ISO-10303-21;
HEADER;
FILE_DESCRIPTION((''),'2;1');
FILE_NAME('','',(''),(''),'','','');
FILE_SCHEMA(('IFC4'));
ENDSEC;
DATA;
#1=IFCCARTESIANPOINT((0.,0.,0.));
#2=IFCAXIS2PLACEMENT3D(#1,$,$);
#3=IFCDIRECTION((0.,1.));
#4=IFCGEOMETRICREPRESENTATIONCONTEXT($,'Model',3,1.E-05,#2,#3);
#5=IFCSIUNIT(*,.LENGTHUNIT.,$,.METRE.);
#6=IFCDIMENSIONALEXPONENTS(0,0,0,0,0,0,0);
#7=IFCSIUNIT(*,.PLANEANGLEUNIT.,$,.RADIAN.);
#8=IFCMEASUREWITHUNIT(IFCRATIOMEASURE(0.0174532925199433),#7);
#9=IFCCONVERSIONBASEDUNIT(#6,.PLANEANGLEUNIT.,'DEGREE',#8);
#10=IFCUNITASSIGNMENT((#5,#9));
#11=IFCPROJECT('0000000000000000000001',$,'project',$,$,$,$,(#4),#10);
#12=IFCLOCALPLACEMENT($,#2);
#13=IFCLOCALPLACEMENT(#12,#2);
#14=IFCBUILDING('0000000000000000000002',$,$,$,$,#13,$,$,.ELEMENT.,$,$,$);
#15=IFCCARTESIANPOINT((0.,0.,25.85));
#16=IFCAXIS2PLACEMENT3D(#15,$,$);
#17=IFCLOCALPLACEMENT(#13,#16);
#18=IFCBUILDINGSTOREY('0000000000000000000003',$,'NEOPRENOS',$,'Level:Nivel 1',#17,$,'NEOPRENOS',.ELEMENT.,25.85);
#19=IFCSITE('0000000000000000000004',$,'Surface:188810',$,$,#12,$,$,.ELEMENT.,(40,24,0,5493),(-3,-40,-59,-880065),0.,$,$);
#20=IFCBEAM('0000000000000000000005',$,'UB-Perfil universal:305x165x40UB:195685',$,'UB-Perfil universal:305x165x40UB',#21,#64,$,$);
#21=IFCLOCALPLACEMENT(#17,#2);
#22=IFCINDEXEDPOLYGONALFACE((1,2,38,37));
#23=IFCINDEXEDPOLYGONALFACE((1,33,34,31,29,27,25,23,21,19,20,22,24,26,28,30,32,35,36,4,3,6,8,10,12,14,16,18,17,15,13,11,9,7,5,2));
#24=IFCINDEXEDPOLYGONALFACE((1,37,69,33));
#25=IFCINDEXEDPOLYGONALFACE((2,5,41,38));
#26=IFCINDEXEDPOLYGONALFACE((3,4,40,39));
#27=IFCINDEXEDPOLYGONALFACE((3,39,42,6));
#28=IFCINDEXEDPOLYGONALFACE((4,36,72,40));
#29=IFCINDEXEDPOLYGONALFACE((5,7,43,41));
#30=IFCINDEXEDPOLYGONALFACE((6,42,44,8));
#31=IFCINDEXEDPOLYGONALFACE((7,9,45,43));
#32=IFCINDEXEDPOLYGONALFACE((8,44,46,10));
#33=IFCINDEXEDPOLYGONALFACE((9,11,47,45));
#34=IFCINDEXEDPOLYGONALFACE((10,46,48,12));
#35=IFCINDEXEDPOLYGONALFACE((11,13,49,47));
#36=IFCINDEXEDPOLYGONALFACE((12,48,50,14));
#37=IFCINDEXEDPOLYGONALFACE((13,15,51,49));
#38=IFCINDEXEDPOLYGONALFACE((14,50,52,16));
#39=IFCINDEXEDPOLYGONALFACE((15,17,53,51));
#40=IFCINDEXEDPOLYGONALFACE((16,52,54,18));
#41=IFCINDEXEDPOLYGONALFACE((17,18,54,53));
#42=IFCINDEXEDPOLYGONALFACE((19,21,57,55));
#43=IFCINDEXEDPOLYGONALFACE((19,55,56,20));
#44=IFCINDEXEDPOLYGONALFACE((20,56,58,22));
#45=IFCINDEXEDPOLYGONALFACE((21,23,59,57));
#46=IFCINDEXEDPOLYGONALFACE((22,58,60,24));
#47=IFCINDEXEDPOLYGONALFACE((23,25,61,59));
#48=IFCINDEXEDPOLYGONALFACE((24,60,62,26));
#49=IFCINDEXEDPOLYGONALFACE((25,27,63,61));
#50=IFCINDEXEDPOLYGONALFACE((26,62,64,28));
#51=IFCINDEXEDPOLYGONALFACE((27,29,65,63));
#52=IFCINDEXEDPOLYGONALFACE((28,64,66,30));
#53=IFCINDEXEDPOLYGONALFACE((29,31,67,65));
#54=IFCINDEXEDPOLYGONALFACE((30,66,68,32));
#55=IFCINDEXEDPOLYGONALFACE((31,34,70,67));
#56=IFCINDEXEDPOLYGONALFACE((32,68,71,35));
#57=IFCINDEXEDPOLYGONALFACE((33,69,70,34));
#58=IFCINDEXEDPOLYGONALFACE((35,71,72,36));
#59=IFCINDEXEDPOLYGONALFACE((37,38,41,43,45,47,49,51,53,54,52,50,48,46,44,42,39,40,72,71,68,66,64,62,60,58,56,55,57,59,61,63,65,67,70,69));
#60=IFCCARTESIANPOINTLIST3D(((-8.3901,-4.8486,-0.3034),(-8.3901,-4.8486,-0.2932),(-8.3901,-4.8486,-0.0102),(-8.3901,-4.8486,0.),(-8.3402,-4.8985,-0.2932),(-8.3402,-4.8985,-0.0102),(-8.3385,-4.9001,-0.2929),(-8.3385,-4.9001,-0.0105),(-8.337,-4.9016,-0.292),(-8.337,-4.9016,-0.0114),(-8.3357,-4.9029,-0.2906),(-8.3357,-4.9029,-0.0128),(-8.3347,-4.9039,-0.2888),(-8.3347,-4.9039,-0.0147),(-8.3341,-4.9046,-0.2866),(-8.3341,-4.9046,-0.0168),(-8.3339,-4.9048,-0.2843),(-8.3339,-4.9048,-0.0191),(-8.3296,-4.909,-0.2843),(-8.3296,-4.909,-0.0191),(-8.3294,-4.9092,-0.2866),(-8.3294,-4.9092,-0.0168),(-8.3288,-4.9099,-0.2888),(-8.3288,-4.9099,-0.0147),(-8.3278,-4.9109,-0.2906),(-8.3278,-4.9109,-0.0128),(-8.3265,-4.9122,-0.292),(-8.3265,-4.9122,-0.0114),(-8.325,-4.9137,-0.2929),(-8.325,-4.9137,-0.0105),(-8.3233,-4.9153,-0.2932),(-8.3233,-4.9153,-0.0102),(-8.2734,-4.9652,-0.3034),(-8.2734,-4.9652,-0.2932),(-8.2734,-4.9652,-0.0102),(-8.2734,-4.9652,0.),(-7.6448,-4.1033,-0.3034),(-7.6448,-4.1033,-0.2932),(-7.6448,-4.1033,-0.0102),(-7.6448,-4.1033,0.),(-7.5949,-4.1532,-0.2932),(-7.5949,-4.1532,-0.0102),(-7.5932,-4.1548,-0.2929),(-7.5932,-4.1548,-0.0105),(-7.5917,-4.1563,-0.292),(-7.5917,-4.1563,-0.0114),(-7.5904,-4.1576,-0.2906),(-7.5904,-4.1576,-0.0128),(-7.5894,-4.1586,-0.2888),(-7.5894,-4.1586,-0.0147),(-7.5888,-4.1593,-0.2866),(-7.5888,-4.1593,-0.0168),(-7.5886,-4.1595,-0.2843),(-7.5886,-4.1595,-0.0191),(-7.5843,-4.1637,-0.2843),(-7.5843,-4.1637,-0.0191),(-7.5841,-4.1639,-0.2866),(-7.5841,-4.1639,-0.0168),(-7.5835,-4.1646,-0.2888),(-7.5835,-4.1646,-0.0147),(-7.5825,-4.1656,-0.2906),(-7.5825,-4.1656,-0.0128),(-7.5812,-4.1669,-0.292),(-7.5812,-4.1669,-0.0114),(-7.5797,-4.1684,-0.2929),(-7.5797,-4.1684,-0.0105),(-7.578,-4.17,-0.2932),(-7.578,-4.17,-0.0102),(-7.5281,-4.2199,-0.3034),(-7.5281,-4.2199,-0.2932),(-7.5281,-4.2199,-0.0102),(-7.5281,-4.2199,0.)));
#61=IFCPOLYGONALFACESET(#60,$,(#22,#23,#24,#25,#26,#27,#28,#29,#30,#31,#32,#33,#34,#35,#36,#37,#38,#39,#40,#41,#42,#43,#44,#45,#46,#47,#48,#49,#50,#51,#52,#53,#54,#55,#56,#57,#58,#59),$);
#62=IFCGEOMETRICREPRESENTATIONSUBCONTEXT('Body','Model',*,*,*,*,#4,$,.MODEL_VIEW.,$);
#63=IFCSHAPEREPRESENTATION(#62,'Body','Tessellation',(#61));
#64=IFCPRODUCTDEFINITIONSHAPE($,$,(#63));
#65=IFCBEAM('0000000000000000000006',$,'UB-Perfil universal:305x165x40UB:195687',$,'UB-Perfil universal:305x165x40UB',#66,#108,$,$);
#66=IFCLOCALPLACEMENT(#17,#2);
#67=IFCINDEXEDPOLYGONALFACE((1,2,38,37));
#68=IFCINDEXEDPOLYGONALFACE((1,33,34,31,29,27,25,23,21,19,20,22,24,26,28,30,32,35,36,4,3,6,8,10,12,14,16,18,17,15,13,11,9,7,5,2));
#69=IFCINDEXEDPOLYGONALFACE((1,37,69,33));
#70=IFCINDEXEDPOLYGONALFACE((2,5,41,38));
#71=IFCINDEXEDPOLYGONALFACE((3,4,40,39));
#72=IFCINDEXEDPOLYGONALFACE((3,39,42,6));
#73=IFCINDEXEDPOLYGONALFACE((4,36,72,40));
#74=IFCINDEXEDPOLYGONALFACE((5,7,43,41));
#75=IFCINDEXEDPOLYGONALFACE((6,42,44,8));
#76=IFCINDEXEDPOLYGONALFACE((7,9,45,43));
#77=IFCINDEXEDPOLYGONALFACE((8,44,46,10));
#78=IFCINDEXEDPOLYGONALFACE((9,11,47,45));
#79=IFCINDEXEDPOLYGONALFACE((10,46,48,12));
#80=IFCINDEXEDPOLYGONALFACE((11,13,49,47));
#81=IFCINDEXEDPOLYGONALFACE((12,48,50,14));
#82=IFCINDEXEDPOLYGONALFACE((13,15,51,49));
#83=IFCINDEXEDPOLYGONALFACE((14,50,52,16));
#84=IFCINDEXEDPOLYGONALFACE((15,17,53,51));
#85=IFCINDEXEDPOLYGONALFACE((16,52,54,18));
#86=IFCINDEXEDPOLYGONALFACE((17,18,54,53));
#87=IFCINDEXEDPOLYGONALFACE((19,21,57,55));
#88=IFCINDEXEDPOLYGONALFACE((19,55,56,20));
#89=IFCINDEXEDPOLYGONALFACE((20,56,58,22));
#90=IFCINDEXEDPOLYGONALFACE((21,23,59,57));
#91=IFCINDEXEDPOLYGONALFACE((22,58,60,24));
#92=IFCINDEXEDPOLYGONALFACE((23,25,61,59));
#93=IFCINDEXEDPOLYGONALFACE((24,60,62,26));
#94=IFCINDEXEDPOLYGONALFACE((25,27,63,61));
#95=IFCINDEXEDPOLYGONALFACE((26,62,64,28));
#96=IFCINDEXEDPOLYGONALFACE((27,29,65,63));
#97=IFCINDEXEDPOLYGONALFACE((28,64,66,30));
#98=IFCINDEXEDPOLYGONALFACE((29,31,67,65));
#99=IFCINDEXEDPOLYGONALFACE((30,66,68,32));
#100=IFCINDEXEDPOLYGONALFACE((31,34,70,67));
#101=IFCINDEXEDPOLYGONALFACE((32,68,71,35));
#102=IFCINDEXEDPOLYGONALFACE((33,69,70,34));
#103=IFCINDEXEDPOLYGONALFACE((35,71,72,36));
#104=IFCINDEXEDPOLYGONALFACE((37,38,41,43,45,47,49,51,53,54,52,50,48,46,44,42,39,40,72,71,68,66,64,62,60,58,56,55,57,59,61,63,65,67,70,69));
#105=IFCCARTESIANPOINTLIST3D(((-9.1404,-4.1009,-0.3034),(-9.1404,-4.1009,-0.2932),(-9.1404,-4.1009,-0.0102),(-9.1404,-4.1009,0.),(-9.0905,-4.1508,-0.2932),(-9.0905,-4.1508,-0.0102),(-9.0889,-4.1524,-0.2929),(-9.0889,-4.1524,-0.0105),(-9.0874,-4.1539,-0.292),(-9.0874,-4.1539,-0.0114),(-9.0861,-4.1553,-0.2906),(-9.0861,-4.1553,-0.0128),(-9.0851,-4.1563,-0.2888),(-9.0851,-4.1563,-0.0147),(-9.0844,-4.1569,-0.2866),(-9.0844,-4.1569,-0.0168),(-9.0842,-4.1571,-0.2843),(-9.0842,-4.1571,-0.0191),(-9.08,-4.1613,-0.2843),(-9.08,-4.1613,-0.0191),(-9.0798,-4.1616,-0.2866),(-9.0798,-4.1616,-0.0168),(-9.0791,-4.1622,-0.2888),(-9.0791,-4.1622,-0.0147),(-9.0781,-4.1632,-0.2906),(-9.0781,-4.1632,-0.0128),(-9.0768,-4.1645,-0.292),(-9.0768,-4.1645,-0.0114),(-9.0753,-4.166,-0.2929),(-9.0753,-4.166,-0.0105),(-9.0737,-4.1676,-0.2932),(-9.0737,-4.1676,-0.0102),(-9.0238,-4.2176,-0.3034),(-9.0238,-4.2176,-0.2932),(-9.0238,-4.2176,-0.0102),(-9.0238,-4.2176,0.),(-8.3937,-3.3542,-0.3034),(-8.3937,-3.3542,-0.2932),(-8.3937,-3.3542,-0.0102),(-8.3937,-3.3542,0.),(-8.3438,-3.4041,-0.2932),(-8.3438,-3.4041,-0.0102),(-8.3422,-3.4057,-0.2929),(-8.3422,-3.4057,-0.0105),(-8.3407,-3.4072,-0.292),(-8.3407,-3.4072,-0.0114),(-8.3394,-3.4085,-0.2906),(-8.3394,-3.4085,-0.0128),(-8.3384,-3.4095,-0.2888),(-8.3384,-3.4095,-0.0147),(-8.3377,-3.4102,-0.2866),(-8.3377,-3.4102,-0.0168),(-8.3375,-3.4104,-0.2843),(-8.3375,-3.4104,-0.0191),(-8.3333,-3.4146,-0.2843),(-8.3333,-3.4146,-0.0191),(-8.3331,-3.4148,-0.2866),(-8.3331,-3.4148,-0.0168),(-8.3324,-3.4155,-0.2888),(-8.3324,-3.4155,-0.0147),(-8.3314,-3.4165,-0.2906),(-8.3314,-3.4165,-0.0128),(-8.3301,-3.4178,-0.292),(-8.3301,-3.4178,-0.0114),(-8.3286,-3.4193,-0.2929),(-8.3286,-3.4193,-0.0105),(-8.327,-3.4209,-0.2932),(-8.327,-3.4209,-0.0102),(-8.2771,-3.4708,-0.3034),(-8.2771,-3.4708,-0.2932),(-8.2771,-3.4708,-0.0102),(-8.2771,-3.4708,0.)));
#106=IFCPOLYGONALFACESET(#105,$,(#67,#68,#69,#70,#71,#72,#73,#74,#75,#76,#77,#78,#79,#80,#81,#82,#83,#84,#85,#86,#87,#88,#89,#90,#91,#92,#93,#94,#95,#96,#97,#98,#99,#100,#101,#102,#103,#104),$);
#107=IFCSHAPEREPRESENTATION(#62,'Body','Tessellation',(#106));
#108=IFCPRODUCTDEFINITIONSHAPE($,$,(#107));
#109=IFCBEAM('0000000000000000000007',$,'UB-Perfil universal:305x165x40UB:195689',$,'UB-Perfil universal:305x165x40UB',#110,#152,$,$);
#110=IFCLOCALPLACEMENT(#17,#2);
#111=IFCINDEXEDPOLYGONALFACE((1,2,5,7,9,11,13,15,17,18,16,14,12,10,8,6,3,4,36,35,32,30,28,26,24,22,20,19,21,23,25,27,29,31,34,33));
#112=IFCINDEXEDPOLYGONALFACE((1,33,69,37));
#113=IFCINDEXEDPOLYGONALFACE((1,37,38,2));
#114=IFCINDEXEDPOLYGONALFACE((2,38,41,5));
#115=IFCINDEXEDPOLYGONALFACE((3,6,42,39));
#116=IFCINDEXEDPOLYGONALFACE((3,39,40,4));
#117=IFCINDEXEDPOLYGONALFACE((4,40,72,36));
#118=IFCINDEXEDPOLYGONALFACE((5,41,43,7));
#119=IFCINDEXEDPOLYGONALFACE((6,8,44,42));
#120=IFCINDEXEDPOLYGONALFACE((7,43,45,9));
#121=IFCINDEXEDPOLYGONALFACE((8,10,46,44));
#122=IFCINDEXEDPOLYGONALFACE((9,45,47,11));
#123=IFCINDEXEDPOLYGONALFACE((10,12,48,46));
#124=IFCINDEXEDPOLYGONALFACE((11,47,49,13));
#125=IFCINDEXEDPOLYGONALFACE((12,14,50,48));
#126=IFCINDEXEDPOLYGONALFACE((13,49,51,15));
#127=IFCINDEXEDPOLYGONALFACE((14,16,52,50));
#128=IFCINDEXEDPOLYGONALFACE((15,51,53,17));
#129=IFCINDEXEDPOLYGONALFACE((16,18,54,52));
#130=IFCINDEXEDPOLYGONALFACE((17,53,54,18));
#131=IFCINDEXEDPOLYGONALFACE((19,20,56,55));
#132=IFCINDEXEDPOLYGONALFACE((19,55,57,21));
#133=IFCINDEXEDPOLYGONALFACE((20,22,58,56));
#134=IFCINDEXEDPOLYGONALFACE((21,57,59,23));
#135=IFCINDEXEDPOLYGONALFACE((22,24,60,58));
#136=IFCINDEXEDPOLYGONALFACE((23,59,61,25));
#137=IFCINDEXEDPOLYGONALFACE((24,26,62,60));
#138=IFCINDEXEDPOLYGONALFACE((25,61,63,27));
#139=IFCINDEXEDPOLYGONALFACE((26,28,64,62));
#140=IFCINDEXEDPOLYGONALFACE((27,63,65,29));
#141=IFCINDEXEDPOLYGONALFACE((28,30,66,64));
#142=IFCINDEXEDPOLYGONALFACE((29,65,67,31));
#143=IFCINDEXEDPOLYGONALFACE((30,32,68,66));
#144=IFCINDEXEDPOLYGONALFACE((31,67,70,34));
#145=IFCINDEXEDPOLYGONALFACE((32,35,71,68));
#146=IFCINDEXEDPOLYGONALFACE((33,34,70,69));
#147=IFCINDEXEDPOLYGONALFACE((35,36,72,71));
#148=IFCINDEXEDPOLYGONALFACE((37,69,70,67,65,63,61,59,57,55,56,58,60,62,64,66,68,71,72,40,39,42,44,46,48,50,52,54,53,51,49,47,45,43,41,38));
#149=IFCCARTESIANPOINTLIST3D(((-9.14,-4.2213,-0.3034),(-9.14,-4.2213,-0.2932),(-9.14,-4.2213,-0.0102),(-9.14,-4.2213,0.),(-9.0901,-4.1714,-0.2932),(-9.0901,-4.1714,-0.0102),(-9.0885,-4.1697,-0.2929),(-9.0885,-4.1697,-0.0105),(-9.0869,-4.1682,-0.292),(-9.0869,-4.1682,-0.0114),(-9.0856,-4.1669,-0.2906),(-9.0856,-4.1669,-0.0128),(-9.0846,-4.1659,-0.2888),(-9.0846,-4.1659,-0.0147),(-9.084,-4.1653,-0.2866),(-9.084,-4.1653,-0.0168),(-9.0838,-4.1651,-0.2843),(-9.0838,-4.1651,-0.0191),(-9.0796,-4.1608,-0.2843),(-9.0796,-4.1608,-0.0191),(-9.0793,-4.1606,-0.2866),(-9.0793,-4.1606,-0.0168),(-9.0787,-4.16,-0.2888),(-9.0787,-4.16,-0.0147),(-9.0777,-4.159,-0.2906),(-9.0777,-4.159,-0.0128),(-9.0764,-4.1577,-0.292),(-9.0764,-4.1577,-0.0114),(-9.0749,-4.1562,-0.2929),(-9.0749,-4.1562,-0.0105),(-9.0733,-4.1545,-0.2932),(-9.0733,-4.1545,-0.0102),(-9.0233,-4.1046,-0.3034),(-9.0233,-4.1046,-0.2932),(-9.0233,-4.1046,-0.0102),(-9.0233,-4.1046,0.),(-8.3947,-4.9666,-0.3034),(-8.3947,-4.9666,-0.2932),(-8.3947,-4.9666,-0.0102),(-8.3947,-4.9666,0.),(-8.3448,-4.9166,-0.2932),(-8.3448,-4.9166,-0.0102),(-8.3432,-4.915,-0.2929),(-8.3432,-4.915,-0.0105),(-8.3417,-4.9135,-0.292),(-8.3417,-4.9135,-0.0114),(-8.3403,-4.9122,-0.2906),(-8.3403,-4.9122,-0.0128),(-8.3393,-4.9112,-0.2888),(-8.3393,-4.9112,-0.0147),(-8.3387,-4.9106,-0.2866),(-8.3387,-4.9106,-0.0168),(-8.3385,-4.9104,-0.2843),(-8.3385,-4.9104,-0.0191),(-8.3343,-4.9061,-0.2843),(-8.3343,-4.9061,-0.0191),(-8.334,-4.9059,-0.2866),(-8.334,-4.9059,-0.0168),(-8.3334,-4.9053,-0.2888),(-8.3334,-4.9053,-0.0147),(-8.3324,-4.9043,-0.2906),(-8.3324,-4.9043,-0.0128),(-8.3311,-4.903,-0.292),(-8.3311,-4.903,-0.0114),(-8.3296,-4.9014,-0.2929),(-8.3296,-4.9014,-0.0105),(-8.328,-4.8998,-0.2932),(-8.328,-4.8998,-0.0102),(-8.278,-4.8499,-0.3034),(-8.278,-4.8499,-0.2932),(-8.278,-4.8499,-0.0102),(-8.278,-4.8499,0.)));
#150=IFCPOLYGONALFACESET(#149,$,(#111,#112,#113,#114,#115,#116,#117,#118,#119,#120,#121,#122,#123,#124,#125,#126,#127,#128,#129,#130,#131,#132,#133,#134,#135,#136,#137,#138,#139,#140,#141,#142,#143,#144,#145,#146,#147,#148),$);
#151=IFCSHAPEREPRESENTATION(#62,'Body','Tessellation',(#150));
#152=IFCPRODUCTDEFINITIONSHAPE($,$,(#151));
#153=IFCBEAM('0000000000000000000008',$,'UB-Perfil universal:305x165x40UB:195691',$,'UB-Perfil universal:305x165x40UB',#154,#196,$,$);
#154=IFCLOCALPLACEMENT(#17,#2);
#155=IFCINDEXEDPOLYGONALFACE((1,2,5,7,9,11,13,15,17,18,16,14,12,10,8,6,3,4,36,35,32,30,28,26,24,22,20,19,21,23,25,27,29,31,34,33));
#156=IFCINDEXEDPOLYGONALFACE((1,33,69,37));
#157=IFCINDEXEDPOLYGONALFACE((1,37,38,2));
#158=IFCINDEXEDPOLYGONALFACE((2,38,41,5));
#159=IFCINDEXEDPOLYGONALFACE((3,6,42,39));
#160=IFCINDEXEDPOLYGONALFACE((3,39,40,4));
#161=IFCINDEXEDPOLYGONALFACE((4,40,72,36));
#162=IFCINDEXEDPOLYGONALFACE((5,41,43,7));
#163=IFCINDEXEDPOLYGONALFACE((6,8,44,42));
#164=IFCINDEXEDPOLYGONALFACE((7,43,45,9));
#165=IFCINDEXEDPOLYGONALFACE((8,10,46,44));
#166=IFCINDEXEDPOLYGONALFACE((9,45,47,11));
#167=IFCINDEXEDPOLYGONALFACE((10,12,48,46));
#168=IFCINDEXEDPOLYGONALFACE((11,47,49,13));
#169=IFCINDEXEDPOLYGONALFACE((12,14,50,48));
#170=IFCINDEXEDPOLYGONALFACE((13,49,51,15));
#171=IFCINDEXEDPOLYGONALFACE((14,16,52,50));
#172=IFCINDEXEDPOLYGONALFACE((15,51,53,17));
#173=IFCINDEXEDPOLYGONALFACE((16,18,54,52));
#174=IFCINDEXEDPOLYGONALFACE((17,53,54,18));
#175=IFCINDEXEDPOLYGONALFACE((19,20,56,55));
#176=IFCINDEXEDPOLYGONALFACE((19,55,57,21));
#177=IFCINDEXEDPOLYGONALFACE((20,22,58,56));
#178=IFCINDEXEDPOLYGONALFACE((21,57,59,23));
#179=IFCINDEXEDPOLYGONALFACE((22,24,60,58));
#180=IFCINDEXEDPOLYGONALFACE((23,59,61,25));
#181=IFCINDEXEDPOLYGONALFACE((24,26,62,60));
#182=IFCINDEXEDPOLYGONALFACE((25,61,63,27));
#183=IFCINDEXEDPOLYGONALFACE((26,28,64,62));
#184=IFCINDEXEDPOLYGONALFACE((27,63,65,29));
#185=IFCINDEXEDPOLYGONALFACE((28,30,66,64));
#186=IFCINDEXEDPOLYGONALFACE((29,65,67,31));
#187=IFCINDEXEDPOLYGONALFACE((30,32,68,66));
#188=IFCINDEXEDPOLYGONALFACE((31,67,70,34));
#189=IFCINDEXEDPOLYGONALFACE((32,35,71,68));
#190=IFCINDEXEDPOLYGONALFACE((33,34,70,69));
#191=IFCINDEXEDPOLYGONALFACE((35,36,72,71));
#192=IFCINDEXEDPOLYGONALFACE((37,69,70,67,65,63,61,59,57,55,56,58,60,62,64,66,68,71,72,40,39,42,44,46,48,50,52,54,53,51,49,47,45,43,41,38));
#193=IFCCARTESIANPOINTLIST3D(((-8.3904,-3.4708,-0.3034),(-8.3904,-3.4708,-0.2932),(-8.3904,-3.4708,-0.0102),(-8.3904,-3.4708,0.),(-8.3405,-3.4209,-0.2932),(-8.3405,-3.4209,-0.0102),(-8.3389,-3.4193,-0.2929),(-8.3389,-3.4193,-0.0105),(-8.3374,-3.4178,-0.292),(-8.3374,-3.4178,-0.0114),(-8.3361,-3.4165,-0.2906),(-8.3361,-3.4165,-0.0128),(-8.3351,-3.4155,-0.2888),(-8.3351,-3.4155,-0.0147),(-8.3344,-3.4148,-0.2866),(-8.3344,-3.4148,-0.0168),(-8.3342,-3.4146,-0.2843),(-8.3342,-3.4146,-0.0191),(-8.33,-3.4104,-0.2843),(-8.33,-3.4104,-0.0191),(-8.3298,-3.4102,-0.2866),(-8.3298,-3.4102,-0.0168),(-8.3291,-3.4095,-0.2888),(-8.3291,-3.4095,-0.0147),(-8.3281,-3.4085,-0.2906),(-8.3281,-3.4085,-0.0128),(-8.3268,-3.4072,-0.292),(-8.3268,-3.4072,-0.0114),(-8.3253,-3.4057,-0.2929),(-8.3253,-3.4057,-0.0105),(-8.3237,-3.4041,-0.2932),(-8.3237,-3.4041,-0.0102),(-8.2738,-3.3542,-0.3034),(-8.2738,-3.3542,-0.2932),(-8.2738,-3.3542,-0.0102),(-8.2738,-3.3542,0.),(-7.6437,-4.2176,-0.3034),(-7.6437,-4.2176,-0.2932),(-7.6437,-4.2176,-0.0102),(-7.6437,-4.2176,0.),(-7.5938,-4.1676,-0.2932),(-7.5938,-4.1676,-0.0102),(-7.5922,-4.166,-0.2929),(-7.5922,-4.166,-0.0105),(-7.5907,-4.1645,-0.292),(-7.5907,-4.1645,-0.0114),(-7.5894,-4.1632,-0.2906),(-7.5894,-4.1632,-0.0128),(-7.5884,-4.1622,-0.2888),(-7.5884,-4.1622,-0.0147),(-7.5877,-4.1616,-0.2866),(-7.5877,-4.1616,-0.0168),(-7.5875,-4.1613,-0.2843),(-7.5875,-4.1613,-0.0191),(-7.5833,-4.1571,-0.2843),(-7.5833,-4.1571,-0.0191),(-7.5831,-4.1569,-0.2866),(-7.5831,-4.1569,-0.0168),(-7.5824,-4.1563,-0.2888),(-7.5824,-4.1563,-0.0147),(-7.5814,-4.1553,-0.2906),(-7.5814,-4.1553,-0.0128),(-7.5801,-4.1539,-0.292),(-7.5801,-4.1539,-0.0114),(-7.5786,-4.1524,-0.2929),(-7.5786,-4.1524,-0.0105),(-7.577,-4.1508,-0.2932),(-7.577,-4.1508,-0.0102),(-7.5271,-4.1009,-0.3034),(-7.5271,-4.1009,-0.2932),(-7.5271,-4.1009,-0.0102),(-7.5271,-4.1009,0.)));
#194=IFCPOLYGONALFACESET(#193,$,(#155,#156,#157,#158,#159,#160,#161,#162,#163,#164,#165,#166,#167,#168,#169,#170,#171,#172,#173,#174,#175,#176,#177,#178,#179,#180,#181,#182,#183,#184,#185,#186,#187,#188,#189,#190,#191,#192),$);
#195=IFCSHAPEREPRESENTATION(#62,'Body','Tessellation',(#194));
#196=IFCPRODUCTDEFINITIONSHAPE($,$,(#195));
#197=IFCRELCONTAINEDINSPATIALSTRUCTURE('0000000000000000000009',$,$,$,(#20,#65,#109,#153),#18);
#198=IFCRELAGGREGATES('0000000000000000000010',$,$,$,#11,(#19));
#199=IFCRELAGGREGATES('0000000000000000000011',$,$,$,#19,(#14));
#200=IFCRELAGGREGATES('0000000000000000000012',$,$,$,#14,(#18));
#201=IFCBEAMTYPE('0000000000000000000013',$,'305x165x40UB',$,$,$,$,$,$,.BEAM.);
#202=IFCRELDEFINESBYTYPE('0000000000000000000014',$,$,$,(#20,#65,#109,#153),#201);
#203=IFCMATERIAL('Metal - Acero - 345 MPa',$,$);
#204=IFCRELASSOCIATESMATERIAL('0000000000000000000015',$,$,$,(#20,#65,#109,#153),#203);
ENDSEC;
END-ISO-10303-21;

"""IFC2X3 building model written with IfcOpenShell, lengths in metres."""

from ifc_helpers import new_model, entity, si_unit, converted_unit, direction, frame, frame_2d, origin, place, context, subcontext, project, spatial, i_section, extrude, material, type_object, element, save


model = new_model("IFC2X3")

# Units and contexts
model_context = context("Model", 3, precision=1e-05, world=origin(), true_north=direction((0.0, 1.0)))
body_context = subcontext(model_context, "Body", "Model", "MODEL_VIEW")
ifc_project = project(units=[si_unit("LENGTHUNIT", "METRE"), converted_unit("PLANEANGLEUNIT", "DEGREE", entity("IfcRatioMeasure", 0.0174532925199433), si_unit("PLANEANGLEUNIT", "RADIAN"), dimensions=[0, 0, 0, 0, 0, 0, 0])], contexts=[model_context])

# Site, building, storey
site_placement = place(None, origin())
site = spatial("IfcSite", under=ifc_project, at=site_placement, Name="Surface:188810", CompositionType="ELEMENT", RefLatitude=(40, 24, 0, 5493), RefLongitude=(-3, -40, -59, -880065), RefElevation=0.0)
building_placement = place(site_placement, origin())
building = spatial("IfcBuilding", under=site, at=building_placement, CompositionType="ELEMENT")
storey_placement = place(building_placement, frame((0.0, 0.0, 25.85)))
storey = spatial("IfcBuildingStorey", under=building, at=storey_placement, Name="NEOPRENOS", ObjectType="Level:Nivel 1", LongName="NEOPRENOS", CompositionType="ELEMENT", Elevation=25.85)

# Beams
ifc_material_1 = material(Name="Metal - Acero - 345 MPa")
beam_type = type_object("IfcBeamType", Name="305x165x40UB", PredefinedType="BEAM")
beam_1_placement = place(storey_placement, frame((-8.3337, -4.9089, 0.0), z_axis=(0.0, 0.0, 1.0), x_axis=(0.707107, 0.707107, 0.0)))
element("IfcBeam", 1, at=beam_1_placement, inside=storey, type_object=beam_type, material=ifc_material_1, Name="UB-Perfil universal:305x165x40UB:195685", ObjectType="UB-Perfil universal:305x165x40UB", context=body_context, shape_type="SweptSolid", body=[
    extrude(i_section(OverallWidth=0.165, OverallDepth=0.3034, WebThickness=0.006, FlangeThickness=0.0102, FilletRadius=0.0089, at=frame_2d((0.0, 0.0), x_axis=(0.0, 1.0))), frame((0.0028, 0.0, -0.1517), z_axis=(1.0, 0.0, 0.0), x_axis=(0.0, 0.0, -1.0)), (0.0, 0.0, 1.0), 1.054),
])
beam_2_placement = place(storey_placement, frame((-8.3337, -3.4109, 0.0), z_axis=(0.0, 0.0, 1.0), x_axis=(-0.707107, -0.707107, 0.0)))
element("IfcBeam", 2, at=beam_2_placement, inside=storey, type_object=beam_type, material=ifc_material_1, Name="UB-Perfil universal:305x165x40UB:195687", ObjectType="UB-Perfil universal:305x165x40UB", context=body_context, shape_type="SweptSolid", body=[
    extrude(i_section(OverallWidth=0.165, OverallDepth=0.3034, WebThickness=0.006, FlangeThickness=0.0102, FilletRadius=0.0089, at=frame_2d((0.0, 0.0), x_axis=(0.0, 1.0))), frame((0.0023, 0.0, -0.1517), z_axis=(1.0, 0.0, 0.0), x_axis=(0.0, 0.0, -1.0)), (0.0, 0.0, 1.0), 1.056),
])
beam_3_placement = place(storey_placement, frame((-9.0837, -4.1609, 0.0), z_axis=(0.0, 0.0, 1.0), x_axis=(0.707107, -0.707107, 0.0)))
element("IfcBeam", 3, at=beam_3_placement, inside=storey, type_object=beam_type, material=ifc_material_1, Name="UB-Perfil universal:305x165x40UB:195689", ObjectType="UB-Perfil universal:305x165x40UB", context=body_context, shape_type="SweptSolid", body=[
    extrude(i_section(OverallWidth=0.165, OverallDepth=0.3034, WebThickness=0.006, FlangeThickness=0.0102, FilletRadius=0.0089, at=frame_2d((0.0, 0.0), x_axis=(0.0, 1.0))), frame((0.0029, 0.0, -0.1517), z_axis=(1.0, 0.0, 0.0), x_axis=(0.0, 0.0, -1.0)), (0.0, 0.0, 1.0), 1.054),
])
beam_4_placement = place(storey_placement, frame((-7.5837, -4.1609, 0.0), z_axis=(0.0, 0.0, 1.0), x_axis=(-0.707107, 0.707107, 0.0)))
element("IfcBeam", 4, at=beam_4_placement, inside=storey, type_object=beam_type, material=ifc_material_1, Name="UB-Perfil universal:305x165x40UB:195691", ObjectType="UB-Perfil universal:305x165x40UB", context=body_context, shape_type="SweptSolid", body=[
    extrude(i_section(OverallWidth=0.165, OverallDepth=0.3034, WebThickness=0.006, FlangeThickness=0.0102, FilletRadius=0.0089, at=frame_2d((0.0, 0.0), x_axis=(0.0, 1.0))), frame((0.0023, 0.0, -0.1517), z_axis=(1.0, 0.0, 0.0), x_axis=(0.0, 0.0, -1.0)), (0.0, 0.0, 1.0), 1.056),
])

save(model, "model.ifc")
